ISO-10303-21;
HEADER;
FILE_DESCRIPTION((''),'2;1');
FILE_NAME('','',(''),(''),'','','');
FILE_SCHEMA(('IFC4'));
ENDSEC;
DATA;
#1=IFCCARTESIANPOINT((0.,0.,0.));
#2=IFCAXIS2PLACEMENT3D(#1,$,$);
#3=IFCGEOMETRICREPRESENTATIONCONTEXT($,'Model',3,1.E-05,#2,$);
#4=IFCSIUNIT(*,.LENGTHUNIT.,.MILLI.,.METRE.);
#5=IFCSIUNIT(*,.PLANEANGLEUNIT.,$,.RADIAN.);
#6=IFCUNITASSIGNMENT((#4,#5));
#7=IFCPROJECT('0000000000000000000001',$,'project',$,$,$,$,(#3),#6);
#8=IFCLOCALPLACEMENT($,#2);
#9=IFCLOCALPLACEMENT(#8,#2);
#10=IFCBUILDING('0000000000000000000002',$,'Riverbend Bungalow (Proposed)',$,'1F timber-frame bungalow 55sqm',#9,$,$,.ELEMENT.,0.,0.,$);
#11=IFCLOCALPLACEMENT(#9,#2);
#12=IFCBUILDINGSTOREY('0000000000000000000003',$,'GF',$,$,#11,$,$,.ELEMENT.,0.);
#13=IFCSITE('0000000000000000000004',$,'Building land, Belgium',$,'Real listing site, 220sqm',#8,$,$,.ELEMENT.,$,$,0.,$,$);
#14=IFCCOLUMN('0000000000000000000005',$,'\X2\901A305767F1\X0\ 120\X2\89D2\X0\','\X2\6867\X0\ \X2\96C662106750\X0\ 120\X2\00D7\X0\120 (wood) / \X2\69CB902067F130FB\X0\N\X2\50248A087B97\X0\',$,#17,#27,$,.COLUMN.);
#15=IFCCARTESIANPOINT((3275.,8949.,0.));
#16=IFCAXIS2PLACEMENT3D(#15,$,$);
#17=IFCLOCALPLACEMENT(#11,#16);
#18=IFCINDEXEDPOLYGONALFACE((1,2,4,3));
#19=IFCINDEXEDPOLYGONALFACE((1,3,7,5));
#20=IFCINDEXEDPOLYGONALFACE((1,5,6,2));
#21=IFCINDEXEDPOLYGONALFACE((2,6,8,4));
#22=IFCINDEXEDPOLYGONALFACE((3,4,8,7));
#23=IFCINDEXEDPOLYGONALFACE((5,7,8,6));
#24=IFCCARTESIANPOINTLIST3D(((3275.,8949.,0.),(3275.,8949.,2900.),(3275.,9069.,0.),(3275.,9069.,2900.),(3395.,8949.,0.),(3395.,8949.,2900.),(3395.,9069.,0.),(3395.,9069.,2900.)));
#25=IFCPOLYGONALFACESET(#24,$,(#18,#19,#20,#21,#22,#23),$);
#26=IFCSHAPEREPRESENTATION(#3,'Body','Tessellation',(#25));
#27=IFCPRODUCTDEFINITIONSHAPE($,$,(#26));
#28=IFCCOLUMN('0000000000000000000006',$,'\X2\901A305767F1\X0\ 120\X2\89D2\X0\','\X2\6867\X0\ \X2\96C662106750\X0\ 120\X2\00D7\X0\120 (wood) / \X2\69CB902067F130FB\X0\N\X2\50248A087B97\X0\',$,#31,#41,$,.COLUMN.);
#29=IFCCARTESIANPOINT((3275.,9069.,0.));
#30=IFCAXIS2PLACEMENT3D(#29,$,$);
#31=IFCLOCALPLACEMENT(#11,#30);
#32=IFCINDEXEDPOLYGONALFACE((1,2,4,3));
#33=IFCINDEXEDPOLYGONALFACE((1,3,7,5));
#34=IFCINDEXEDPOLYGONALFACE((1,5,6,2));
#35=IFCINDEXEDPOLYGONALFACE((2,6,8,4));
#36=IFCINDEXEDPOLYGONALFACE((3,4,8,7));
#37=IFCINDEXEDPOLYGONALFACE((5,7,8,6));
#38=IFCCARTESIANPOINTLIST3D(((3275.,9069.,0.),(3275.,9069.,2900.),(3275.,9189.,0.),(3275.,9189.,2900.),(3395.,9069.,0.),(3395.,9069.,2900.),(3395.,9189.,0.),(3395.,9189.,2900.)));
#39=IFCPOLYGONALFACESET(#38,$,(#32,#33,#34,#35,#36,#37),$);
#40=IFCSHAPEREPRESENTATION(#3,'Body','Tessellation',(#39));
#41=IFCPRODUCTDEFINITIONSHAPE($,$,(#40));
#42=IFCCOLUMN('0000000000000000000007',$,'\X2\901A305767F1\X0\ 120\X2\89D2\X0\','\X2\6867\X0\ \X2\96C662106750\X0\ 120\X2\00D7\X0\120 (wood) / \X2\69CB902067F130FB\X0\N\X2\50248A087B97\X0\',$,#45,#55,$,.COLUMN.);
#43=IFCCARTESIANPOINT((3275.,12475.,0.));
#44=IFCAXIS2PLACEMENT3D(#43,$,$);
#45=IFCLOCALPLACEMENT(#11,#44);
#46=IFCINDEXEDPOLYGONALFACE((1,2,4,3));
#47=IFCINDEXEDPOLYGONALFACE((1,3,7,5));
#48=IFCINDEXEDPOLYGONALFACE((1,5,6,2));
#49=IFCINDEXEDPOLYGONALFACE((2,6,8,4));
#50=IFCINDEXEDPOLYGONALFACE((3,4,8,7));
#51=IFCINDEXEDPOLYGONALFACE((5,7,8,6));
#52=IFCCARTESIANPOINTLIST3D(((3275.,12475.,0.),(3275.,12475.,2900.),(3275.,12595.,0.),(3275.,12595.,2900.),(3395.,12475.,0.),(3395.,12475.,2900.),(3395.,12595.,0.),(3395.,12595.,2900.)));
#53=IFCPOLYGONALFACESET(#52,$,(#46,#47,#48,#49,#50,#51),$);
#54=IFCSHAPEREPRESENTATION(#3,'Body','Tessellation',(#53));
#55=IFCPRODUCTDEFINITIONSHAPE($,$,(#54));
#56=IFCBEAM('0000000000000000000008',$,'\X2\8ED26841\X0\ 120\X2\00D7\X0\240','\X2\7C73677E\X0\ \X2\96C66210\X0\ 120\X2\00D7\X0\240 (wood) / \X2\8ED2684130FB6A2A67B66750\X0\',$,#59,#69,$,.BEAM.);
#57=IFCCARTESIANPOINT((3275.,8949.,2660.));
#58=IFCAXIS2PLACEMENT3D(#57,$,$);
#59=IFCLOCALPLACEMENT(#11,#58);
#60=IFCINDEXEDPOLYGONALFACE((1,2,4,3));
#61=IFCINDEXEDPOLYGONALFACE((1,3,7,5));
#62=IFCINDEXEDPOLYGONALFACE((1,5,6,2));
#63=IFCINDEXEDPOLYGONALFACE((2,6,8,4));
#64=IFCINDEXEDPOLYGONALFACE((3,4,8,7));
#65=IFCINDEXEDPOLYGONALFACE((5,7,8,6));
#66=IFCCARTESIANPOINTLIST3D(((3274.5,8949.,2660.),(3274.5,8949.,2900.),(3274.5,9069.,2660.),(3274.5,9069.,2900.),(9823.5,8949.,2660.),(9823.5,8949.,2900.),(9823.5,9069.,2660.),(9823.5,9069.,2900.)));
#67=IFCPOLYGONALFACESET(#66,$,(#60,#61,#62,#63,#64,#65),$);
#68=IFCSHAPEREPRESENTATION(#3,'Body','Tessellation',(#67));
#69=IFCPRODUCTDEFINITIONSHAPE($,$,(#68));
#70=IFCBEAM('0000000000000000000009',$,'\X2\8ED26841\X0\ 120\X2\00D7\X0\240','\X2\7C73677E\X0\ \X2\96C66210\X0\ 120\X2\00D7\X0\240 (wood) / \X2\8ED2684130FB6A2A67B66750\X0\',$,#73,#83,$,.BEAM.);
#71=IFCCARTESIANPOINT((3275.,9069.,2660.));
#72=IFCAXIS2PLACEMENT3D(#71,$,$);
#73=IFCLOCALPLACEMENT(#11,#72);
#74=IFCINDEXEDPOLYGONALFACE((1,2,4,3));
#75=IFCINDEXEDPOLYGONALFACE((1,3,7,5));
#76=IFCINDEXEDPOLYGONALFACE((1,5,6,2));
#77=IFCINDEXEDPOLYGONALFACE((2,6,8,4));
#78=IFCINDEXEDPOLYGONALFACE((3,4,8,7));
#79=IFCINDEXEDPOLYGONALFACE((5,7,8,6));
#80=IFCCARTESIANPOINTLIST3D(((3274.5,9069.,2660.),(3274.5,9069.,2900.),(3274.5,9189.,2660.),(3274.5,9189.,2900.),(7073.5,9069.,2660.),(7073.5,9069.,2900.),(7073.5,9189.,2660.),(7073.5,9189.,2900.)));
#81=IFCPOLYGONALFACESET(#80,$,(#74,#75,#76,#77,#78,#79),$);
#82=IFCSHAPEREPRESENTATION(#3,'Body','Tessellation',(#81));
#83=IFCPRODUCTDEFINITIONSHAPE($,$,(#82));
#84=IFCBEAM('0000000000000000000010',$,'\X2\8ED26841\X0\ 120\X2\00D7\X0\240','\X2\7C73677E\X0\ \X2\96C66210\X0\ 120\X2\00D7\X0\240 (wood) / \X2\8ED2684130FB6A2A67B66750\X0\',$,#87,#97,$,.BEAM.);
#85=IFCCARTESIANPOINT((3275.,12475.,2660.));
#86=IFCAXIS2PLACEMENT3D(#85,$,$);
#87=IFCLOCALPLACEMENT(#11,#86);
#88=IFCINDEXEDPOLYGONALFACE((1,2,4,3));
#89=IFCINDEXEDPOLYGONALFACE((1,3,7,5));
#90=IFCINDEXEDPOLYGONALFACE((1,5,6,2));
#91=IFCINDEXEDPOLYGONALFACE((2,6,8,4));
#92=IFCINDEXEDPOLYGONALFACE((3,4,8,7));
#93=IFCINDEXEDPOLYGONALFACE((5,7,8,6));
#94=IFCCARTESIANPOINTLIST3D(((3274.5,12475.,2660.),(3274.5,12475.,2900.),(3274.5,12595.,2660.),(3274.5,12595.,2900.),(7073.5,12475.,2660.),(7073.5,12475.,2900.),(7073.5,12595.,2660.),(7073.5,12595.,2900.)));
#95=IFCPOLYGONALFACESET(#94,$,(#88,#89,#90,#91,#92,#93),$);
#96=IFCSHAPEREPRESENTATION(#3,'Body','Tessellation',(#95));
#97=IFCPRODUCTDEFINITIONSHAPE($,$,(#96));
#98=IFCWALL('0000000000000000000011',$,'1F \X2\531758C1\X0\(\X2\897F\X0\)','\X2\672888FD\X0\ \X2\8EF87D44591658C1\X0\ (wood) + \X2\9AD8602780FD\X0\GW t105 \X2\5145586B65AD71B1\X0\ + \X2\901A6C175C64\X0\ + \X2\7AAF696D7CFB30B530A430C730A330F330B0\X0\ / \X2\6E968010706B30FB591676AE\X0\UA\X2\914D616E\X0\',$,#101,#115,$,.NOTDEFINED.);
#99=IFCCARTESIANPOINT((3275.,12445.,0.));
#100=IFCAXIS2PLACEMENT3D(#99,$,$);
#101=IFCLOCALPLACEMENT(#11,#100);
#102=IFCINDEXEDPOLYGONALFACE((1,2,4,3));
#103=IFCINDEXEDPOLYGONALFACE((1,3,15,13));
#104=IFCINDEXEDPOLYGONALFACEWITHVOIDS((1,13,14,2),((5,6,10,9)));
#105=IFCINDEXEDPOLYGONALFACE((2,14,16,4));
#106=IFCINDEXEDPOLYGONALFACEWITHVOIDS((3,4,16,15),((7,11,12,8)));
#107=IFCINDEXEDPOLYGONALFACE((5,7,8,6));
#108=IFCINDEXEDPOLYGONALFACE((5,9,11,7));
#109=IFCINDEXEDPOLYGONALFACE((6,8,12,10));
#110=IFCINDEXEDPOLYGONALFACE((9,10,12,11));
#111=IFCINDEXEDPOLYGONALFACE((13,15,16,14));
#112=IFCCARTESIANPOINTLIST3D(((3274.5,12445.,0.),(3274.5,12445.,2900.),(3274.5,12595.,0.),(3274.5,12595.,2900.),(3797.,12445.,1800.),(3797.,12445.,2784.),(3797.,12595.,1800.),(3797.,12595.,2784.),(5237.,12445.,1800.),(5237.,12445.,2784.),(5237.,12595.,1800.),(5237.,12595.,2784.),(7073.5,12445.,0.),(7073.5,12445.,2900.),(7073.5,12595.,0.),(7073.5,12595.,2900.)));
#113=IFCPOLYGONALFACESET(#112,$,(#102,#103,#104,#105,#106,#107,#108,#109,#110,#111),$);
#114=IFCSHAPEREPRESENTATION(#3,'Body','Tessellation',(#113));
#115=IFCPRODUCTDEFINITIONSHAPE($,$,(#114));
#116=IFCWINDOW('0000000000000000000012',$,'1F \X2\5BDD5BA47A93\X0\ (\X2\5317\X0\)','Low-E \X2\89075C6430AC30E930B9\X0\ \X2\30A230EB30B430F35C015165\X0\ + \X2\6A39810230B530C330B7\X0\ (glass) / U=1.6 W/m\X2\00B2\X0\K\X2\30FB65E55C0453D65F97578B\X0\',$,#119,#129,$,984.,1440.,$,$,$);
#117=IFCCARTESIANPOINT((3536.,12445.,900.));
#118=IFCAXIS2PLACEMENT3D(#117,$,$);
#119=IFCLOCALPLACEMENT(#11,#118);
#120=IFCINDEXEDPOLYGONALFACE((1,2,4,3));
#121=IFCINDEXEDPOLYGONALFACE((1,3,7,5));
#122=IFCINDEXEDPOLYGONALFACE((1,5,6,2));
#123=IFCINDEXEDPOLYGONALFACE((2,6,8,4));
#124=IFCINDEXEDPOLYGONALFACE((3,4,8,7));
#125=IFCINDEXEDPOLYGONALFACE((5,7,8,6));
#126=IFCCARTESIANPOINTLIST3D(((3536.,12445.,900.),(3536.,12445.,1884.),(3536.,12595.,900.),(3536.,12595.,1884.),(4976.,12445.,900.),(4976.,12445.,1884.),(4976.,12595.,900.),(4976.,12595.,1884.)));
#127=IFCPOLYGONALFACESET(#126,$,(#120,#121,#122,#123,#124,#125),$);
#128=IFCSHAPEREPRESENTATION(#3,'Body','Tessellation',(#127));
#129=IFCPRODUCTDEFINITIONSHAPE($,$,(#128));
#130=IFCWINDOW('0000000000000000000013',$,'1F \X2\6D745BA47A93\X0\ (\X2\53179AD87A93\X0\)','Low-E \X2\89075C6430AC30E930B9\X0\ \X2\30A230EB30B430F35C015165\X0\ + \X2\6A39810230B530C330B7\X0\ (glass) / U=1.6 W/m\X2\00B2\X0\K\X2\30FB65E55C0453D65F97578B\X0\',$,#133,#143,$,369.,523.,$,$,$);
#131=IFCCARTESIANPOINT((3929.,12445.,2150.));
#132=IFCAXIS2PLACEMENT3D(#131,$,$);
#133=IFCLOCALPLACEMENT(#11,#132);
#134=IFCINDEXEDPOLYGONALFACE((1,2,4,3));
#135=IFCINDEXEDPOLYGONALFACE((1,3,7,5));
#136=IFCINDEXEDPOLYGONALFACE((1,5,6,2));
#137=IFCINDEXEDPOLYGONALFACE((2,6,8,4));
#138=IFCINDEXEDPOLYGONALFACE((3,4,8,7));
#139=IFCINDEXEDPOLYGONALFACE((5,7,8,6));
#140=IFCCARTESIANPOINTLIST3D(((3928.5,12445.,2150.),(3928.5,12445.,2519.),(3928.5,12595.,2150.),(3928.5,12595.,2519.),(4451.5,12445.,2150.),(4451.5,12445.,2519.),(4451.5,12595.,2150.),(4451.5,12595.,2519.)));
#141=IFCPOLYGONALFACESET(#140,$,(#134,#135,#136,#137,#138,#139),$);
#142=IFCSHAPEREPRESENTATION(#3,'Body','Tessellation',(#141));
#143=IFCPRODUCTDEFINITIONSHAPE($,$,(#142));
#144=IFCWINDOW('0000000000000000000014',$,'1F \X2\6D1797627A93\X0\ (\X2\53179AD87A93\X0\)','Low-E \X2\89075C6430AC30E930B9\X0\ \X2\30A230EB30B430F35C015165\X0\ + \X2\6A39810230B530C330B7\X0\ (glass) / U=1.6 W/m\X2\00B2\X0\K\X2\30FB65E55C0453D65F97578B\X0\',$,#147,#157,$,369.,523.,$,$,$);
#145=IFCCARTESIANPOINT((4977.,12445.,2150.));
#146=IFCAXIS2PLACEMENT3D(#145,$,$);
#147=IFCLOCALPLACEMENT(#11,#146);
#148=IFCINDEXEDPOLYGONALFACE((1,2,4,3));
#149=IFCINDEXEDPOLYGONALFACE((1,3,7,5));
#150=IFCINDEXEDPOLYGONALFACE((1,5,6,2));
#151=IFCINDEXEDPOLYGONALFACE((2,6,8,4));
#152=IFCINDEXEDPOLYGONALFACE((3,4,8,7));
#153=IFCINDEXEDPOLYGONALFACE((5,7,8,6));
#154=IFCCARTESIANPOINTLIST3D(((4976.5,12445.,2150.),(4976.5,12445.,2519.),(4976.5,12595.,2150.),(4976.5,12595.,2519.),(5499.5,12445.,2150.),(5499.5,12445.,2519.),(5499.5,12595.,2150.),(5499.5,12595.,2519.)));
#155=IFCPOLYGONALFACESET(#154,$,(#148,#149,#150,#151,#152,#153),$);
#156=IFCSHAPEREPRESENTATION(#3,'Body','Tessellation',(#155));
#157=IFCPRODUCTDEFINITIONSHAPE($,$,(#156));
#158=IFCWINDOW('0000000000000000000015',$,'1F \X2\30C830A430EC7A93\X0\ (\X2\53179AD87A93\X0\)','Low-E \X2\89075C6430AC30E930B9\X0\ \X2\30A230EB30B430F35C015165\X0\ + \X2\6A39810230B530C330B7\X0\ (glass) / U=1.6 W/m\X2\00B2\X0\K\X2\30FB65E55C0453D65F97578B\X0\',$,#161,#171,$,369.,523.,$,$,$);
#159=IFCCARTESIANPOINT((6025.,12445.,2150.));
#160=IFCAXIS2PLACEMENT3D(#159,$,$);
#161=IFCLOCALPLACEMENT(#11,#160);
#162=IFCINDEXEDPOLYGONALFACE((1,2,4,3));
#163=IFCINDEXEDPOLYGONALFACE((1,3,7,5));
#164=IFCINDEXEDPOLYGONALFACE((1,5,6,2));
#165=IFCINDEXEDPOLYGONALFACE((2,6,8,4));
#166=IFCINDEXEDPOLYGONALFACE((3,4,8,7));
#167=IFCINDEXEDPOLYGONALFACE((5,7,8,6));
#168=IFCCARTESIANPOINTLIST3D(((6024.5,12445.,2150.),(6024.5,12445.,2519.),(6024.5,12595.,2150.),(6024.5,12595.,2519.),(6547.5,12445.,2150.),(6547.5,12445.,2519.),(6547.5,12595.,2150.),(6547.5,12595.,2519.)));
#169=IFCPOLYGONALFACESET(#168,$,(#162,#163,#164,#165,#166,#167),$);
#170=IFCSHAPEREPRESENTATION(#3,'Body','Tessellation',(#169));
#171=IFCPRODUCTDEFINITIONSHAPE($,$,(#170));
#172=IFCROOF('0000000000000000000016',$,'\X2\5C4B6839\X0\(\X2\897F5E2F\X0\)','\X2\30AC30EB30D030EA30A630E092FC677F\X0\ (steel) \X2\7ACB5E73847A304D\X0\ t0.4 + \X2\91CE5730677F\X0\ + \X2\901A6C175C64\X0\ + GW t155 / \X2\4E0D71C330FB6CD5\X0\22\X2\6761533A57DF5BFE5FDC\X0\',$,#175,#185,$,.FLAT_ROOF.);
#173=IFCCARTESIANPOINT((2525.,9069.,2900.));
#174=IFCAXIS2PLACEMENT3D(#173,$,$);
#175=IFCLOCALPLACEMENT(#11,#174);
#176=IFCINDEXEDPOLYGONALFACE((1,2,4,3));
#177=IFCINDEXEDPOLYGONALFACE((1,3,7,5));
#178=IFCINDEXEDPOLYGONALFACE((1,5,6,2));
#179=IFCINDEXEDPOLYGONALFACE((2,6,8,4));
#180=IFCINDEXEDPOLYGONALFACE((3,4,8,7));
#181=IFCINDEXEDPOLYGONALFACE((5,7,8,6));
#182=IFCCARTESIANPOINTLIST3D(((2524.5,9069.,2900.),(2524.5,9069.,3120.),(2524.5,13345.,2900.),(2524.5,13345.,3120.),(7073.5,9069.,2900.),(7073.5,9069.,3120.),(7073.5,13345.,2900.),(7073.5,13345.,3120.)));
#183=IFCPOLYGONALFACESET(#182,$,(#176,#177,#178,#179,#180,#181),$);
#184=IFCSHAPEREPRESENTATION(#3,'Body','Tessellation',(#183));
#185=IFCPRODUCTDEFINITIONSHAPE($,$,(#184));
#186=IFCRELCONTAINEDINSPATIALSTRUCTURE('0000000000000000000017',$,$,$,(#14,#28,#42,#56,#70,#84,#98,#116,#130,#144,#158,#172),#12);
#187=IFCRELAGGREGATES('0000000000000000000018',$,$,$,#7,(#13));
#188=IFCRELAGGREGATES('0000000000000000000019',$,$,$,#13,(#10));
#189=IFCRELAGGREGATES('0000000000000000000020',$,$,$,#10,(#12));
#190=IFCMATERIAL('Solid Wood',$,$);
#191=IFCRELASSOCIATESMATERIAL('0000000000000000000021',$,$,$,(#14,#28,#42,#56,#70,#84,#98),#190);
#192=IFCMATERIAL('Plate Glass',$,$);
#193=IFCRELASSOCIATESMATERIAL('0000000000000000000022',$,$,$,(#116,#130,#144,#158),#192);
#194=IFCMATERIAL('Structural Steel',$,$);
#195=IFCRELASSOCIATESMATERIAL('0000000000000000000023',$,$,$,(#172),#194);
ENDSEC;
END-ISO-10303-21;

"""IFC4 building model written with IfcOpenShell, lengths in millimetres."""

from ifc_helpers import new_model, si_unit, frame, frame_2d, origin, place, context, project, spatial, rectangle, extrude, material, element, fill, save


model = new_model("IFC4")

# Units and contexts
model_context = context("Model", 3, precision=1e-05, world=origin())
ifc_project = project(units=[si_unit("LENGTHUNIT", "METRE", prefix="MILLI"), si_unit("PLANEANGLEUNIT", "RADIAN")], contexts=[model_context])

# Site, building, storey
site_placement = place(None, origin())
site = spatial("IfcSite", under=ifc_project, at=site_placement, Name="Building land, Belgium", ObjectType="Real listing site, 220sqm", CompositionType="ELEMENT", RefElevation=0.0)
building_placement = place(site_placement, origin())
building = spatial("IfcBuilding", under=site, at=building_placement, Name="Riverbend Bungalow (Proposed)", ObjectType="1F timber-frame bungalow 55sqm", CompositionType="ELEMENT", ElevationOfRefHeight=0.0, ElevationOfTerrain=0.0)
storey_placement = place(building_placement, origin())
storey = spatial("IfcBuildingStorey", under=building, at=storey_placement, Name="GF", CompositionType="ELEMENT", Elevation=0.0)

# Columns
ifc_material_1 = material(Name="Solid Wood")
column_1_placement = place(storey_placement, frame((3275.0, 8949.0, 0.0)))
element("IfcColumn", 1, at=column_1_placement, inside=storey, material=ifc_material_1, Name="通し柱 120角", Description="桧 集成材 120×120 (wood) / 構造柱・N値計算", PredefinedType="COLUMN", context=model_context, shape_type="SweptSolid", body=[
    extrude(rectangle(XDim=120.0, YDim=120.0, at=frame_2d((60.0, 60.0))), frame((3275.0, 8949.0, 0.0)), (0.0, 0.0, 1.0), 2900.0),
])
column_2_placement = place(storey_placement, frame((3275.0, 9069.0, 0.0)))
element("IfcColumn", 2, at=column_2_placement, inside=storey, material=ifc_material_1, Name="通し柱 120角", Description="桧 集成材 120×120 (wood) / 構造柱・N値計算", PredefinedType="COLUMN", context=model_context, shape_type="SweptSolid", body=[
    extrude(rectangle(XDim=120.0, YDim=120.0, at=frame_2d((60.0, 60.0))), frame((3275.0, 9069.0, 0.0)), (0.0, 0.0, 1.0), 2900.0),
])
column_3_placement = place(storey_placement, frame((3275.0, 12475.0, 0.0)))
element("IfcColumn", 3, at=column_3_placement, inside=storey, material=ifc_material_1, Name="通し柱 120角", Description="桧 集成材 120×120 (wood) / 構造柱・N値計算", PredefinedType="COLUMN", context=model_context, shape_type="SweptSolid", body=[
    extrude(rectangle(XDim=120.0, YDim=120.0, at=frame_2d((60.0, 60.0))), frame((3275.0, 12475.0, 0.0)), (0.0, 0.0, 1.0), 2900.0),
])

# Beams
beam_1_placement = place(storey_placement, frame((3275.0, 8949.0, 2660.0)))
element("IfcBeam", 4, at=beam_1_placement, inside=storey, material=ifc_material_1, Name="軒桁 120×240", Description="米松 集成 120×240 (wood) / 軒桁・横架材", PredefinedType="BEAM", context=model_context, shape_type="SweptSolid", body=[
    extrude(rectangle(XDim=6549.0, YDim=120.0, at=frame_2d((3274.0, 60.0))), frame((3275.0, 8949.0, 2660.0)), (0.0, 0.0, 1.0), 240.0),
])
beam_2_placement = place(storey_placement, frame((3275.0, 9069.0, 2660.0)))
element("IfcBeam", 5, at=beam_2_placement, inside=storey, material=ifc_material_1, Name="軒桁 120×240", Description="米松 集成 120×240 (wood) / 軒桁・横架材", PredefinedType="BEAM", context=model_context, shape_type="SweptSolid", body=[
    extrude(rectangle(XDim=3799.0, YDim=120.0, at=frame_2d((1899.0, 60.0))), frame((3275.0, 9069.0, 2660.0)), (0.0, 0.0, 1.0), 240.0),
])
beam_3_placement = place(storey_placement, frame((3275.0, 12475.0, 2660.0)))
element("IfcBeam", 6, at=beam_3_placement, inside=storey, material=ifc_material_1, Name="軒桁 120×240", Description="米松 集成 120×240 (wood) / 軒桁・横架材", PredefinedType="BEAM", context=model_context, shape_type="SweptSolid", body=[
    extrude(rectangle(XDim=3799.0, YDim=120.0, at=frame_2d((1899.0, 60.0))), frame((3275.0, 12475.0, 2660.0)), (0.0, 0.0, 1.0), 240.0),
])

# Wall, openings, windows
wall_1_placement = place(storey_placement, frame((3275.0, 12445.0, 0.0)))
wall_1 = element("IfcWall", 7, at=wall_1_placement, inside=storey, material=ifc_material_1, Name="1F 北壁(西)", Description="木製 軸組外壁 (wood) + 高性能GW t105 充填断熱 + 通気層 + 窯業系サイディング / 準耐火・外皮UA配慮", PredefinedType="NOTDEFINED", context=model_context, shape_type="SweptSolid", body=[
    extrude(rectangle(XDim=3799.0, YDim=150.0, at=frame_2d((1899.0, 75.0))), frame((3275.0, 12445.0, 0.0)), (0.0, 0.0, 1.0), 2900.0),
])
opening_1_placement = place(storey_placement, frame((3536.0, 12445.0, 900.0)))
opening_1 = element("IfcOpeningElement", 8, at=opening_1_placement, cuts=wall_1, PredefinedType="NOTDEFINED", context=model_context, shape_type="SweptSolid", body=[
    extrude(rectangle(XDim=1440.0, YDim=150.0, at=frame_2d((720.0, 75.0))), frame((3536.0, 12445.0, 900.0)), (0.0, 0.0, 1.0), 984.0),
])
opening_2_placement = place(storey_placement, frame((3929.0, 12445.0, 2150.0)))
opening_2 = element("IfcOpeningElement", 9, at=opening_2_placement, cuts=wall_1, PredefinedType="NOTDEFINED", context=model_context, shape_type="SweptSolid", body=[
    extrude(rectangle(XDim=523.0, YDim=150.0, at=frame_2d((261.0, 75.0))), frame((3929.0, 12445.0, 2150.0)), (0.0, 0.0, 1.0), 369.0),
])
opening_3_placement = place(storey_placement, frame((4977.0, 12445.0, 2150.0)))
opening_3 = element("IfcOpeningElement", 10, at=opening_3_placement, cuts=wall_1, PredefinedType="NOTDEFINED", context=model_context, shape_type="SweptSolid", body=[
    extrude(rectangle(XDim=523.0, YDim=150.0, at=frame_2d((261.0, 75.0))), frame((4977.0, 12445.0, 2150.0)), (0.0, 0.0, 1.0), 369.0),
])
opening_4_placement = place(storey_placement, frame((6025.0, 12445.0, 2150.0)))
opening_4 = element("IfcOpeningElement", 11, at=opening_4_placement, cuts=wall_1, PredefinedType="NOTDEFINED", context=model_context, shape_type="SweptSolid", body=[
    extrude(rectangle(XDim=523.0, YDim=150.0, at=frame_2d((261.0, 75.0))), frame((6025.0, 12445.0, 2150.0)), (0.0, 0.0, 1.0), 369.0),
])
ifc_material_2 = material(Name="Plate Glass")
window_1_placement = place(storey_placement, frame((3536.0, 12445.0, 900.0)))
window_1 = element("IfcWindow", 12, at=window_1_placement, inside=storey, material=ifc_material_2, Name="1F 寝室窓 (北)", Description="Low-E 複層ガラス アルゴン封入 + 樹脂サッシ (glass) / U=1.6 W/m²K・日射取得型", OverallHeight=984.0, OverallWidth=1440.0, context=model_context, shape_type="SweptSolid", body=[
    extrude(rectangle(XDim=1440.0, YDim=150.0, at=frame_2d((720.0, 75.0))), frame((3536.0, 12445.0, 900.0)), (0.0, 0.0, 1.0), 984.0),
])
fill(opening_1, window_1)
window_2_placement = place(storey_placement, frame((3929.0, 12445.0, 2150.0)))
window_2 = element("IfcWindow", 13, at=window_2_placement, inside=storey, material=ifc_material_2, Name="1F 浴室窓 (北高窓)", Description="Low-E 複層ガラス アルゴン封入 + 樹脂サッシ (glass) / U=1.6 W/m²K・日射取得型", OverallHeight=369.0, OverallWidth=523.0, context=model_context, shape_type="SweptSolid", body=[
    extrude(rectangle(XDim=523.0, YDim=150.0, at=frame_2d((261.0, 75.0))), frame((3929.0, 12445.0, 2150.0)), (0.0, 0.0, 1.0), 369.0),
])
fill(opening_2, window_2)
window_3_placement = place(storey_placement, frame((4977.0, 12445.0, 2150.0)))
window_3 = element("IfcWindow", 14, at=window_3_placement, inside=storey, material=ifc_material_2, Name="1F 洗面窓 (北高窓)", Description="Low-E 複層ガラス アルゴン封入 + 樹脂サッシ (glass) / U=1.6 W/m²K・日射取得型", OverallHeight=369.0, OverallWidth=523.0, context=model_context, shape_type="SweptSolid", body=[
    extrude(rectangle(XDim=523.0, YDim=150.0, at=frame_2d((261.0, 75.0))), frame((4977.0, 12445.0, 2150.0)), (0.0, 0.0, 1.0), 369.0),
])
fill(opening_3, window_3)
window_4_placement = place(storey_placement, frame((6025.0, 12445.0, 2150.0)))
window_4 = element("IfcWindow", 15, at=window_4_placement, inside=storey, material=ifc_material_2, Name="1F トイレ窓 (北高窓)", Description="Low-E 複層ガラス アルゴン封入 + 樹脂サッシ (glass) / U=1.6 W/m²K・日射取得型", OverallHeight=369.0, OverallWidth=523.0, context=model_context, shape_type="SweptSolid", body=[
    extrude(rectangle(XDim=523.0, YDim=150.0, at=frame_2d((261.0, 75.0))), frame((6025.0, 12445.0, 2150.0)), (0.0, 0.0, 1.0), 369.0),
])
fill(opening_4, window_4)

# Roof
ifc_material_3 = material(Name="Structural Steel")
roof_placement = place(storey_placement, frame((2525.0, 9069.0, 2900.0)))
element("IfcRoof", 16, at=roof_placement, inside=storey, material=ifc_material_3, Name="屋根(西帯)", Description="ガルバリウム鋼板 (steel) 立平葺き t0.4 + 野地板 + 通気層 + GW t155 / 不燃・法22条区域対応", PredefinedType="FLAT_ROOF", context=model_context, shape_type="SweptSolid", body=[
    extrude(rectangle(XDim=4549.0, YDim=4276.0, at=frame_2d((2274.0, 2138.0))), frame((2525.0, 9069.0, 2900.0)), (0.0, 0.0, 1.0), 220.0),
])

save(model, "model.ifc")
